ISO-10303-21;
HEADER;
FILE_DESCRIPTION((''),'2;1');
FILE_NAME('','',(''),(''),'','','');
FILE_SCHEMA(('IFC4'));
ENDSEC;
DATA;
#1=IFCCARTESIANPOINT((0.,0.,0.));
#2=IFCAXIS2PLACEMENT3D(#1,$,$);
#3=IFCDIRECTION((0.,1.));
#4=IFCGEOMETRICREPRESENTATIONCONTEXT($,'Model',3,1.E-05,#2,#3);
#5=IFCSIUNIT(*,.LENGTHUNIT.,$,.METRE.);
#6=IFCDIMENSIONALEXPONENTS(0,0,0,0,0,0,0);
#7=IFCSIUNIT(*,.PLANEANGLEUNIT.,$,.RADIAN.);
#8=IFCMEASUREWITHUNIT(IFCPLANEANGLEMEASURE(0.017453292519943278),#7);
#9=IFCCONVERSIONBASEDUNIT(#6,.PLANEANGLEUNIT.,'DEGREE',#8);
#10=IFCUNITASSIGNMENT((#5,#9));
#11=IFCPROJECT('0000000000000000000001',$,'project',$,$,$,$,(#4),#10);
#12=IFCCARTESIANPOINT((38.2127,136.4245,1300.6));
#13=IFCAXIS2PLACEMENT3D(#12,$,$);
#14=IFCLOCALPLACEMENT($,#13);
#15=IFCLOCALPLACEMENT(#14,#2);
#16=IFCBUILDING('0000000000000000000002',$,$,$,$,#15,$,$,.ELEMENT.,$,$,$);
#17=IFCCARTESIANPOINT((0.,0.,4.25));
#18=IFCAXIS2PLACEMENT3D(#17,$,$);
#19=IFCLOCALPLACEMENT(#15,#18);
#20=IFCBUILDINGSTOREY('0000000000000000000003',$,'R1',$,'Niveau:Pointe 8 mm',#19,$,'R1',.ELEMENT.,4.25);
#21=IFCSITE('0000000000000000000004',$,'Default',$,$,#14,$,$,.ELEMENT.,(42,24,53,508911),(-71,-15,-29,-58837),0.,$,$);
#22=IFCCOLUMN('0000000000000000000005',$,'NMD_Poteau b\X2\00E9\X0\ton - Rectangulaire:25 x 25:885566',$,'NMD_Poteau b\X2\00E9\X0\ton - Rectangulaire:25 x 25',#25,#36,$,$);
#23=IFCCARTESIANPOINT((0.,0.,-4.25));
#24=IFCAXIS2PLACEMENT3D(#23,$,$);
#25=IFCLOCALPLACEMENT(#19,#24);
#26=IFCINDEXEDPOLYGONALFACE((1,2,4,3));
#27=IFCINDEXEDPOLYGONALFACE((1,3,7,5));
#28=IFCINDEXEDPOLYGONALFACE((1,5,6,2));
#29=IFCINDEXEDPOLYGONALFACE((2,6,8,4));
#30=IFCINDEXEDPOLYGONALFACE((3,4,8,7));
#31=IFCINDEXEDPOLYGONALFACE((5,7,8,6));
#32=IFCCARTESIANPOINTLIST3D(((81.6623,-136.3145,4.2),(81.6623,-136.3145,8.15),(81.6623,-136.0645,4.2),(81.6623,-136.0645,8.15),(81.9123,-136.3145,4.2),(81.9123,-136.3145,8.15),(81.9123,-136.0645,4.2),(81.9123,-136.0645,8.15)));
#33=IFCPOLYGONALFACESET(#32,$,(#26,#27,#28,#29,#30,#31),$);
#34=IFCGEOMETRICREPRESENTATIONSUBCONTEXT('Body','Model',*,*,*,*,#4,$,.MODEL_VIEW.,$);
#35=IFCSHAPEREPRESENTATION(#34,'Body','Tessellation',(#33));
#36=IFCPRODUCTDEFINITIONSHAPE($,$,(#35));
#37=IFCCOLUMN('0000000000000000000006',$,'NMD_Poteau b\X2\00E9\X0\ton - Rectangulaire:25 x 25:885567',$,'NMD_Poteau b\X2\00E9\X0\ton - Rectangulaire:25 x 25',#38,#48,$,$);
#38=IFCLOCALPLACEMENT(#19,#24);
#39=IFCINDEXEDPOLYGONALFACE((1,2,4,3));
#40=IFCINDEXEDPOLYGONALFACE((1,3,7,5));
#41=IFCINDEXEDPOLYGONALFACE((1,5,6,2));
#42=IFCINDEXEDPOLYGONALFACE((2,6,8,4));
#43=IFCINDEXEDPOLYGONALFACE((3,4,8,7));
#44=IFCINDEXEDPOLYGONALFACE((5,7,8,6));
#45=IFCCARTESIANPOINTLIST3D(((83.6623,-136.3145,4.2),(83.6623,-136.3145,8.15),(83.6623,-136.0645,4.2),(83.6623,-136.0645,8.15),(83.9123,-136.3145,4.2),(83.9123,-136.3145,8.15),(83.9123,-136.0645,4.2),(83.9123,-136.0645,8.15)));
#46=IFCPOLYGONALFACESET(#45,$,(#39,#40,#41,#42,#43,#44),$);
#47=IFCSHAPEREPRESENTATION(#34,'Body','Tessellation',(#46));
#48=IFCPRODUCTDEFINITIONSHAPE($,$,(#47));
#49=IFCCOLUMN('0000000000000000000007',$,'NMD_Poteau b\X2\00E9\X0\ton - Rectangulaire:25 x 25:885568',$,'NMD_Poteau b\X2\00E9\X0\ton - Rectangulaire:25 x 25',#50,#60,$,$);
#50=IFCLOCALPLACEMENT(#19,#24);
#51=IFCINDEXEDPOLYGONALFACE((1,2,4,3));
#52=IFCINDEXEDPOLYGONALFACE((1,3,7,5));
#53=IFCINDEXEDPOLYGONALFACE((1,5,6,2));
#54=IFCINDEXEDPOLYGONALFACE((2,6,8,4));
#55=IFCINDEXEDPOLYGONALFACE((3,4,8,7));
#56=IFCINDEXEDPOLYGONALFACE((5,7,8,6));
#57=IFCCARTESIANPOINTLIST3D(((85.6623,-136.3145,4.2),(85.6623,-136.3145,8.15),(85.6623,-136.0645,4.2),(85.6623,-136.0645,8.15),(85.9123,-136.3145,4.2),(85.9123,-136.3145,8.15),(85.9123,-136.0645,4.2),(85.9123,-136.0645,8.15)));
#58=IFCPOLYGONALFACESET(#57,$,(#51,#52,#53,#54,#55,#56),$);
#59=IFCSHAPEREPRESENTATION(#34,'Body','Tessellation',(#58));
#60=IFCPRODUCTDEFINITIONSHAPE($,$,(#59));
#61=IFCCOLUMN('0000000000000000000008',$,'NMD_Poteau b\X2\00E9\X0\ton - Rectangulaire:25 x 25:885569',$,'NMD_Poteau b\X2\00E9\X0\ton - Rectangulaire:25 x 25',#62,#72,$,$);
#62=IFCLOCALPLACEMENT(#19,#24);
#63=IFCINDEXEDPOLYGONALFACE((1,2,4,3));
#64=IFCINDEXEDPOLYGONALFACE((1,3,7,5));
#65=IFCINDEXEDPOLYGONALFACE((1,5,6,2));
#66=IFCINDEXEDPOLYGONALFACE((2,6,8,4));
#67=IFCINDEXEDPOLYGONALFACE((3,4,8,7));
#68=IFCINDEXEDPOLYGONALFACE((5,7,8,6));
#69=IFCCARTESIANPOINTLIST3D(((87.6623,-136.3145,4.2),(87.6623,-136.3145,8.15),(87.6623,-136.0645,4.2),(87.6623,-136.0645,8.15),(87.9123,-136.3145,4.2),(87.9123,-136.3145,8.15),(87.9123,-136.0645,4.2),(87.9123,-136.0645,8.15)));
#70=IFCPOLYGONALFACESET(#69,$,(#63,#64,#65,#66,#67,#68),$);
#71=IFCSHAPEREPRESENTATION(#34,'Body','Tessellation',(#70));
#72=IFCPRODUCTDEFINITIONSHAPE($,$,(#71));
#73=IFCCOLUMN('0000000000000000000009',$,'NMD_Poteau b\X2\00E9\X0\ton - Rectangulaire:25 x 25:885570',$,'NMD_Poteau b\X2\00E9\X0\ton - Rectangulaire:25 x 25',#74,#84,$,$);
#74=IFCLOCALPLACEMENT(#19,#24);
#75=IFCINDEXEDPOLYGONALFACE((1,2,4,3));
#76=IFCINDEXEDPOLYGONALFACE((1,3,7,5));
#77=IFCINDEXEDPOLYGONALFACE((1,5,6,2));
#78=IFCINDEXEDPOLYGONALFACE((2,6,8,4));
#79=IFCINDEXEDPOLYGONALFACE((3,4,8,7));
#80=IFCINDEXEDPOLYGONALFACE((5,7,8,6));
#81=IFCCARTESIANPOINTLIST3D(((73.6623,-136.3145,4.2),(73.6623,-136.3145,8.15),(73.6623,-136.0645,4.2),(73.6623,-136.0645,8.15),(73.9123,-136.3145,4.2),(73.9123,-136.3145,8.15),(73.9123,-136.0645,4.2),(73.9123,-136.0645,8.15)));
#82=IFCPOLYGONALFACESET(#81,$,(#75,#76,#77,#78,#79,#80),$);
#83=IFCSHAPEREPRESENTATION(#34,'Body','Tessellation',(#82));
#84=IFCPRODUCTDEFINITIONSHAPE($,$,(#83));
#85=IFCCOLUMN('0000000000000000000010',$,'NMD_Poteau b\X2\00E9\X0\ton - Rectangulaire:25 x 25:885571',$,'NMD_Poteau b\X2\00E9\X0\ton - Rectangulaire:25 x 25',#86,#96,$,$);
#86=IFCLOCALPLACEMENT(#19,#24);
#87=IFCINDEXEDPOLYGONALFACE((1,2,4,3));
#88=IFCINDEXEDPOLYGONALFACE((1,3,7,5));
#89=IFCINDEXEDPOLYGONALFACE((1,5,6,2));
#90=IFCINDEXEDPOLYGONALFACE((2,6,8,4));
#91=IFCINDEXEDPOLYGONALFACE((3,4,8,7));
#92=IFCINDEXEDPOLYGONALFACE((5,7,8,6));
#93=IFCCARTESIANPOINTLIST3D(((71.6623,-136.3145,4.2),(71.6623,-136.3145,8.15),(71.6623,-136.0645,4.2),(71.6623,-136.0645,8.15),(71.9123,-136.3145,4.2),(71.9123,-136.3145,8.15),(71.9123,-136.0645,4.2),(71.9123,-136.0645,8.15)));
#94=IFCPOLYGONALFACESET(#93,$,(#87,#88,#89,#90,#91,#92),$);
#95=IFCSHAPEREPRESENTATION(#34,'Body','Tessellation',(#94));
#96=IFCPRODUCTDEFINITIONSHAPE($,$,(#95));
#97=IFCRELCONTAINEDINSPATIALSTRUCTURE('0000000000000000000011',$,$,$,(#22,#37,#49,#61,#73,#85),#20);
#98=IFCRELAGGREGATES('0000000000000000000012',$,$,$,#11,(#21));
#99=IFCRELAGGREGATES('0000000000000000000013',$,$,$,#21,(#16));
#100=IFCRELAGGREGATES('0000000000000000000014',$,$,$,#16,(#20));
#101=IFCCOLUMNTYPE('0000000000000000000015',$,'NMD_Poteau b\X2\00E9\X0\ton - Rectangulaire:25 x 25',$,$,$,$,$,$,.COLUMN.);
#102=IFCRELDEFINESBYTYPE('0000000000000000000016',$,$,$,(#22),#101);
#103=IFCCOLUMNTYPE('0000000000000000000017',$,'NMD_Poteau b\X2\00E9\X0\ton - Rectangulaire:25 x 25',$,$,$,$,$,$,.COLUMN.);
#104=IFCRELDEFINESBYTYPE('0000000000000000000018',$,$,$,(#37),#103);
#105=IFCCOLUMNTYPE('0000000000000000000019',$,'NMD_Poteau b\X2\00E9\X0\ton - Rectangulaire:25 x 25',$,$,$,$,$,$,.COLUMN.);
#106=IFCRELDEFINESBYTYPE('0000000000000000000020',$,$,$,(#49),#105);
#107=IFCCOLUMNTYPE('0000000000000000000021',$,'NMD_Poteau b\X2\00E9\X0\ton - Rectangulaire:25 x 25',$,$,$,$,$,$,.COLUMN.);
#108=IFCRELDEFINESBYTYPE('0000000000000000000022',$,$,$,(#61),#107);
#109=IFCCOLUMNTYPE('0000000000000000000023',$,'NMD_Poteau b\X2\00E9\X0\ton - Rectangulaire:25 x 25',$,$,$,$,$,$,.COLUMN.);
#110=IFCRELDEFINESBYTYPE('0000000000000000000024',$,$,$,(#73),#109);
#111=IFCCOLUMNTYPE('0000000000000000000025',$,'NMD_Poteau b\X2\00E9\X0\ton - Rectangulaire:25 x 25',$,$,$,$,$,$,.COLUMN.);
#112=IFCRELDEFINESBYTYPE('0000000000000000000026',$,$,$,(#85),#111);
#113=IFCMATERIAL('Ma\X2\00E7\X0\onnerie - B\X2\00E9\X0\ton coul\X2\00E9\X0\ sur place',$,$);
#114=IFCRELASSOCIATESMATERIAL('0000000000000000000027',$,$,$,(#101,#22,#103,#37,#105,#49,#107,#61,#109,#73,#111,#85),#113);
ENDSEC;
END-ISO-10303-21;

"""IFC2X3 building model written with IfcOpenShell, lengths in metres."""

from ifc_helpers import new_model, entity, si_unit, converted_unit, direction, frame, frame_2d, origin, place, context, subcontext, project, spatial, rectangle, extrude, source, transform, mapped, material, type_object, type_shapes, element, save


model = new_model("IFC2X3")

# Units and contexts
model_context = context("Model", 3, precision=1e-05, world=origin(), true_north=direction((0.0, 1.0)))
body_context = subcontext(model_context, "Body", "Model", "MODEL_VIEW")
ifc_project = project(units=[si_unit("LENGTHUNIT", "METRE"), converted_unit("PLANEANGLEUNIT", "DEGREE", entity("IfcPlaneAngleMeasure", 0.017453292519943278), si_unit("PLANEANGLEUNIT", "RADIAN"), dimensions=[0, 0, 0, 0, 0, 0, 0])], contexts=[model_context])

# Site, building, storey
site_placement = place(None, frame((38.2127, 136.4245, 1300.6)))
site = spatial("IfcSite", under=ifc_project, at=site_placement, Name="Default", CompositionType="ELEMENT", RefLatitude=(42, 24, 53, 508911), RefLongitude=(-71, -15, -29, -58837), RefElevation=0.0)
building_placement = place(site_placement, origin())
building = spatial("IfcBuilding", under=site, at=building_placement, CompositionType="ELEMENT")
storey_placement = place(building_placement, frame((0.0, 0.0, 4.25)))
storey = spatial("IfcBuildingStorey", under=building, at=storey_placement, Name="R1", ObjectType="Niveau:Pointe 8 mm", LongName="R1", CompositionType="ELEMENT", Elevation=4.25)

# Columns
ifc_material_1 = material(Name="Maçonnerie - Béton coulé sur place")
column_type_1 = type_object("IfcColumnType", Name="NMD_Poteau béton - Rectangulaire:25 x 25", PredefinedType="COLUMN", material=ifc_material_1)
shared_shape_1 = source(origin(), body_context, "Body", "SweptSolid", [
    extrude(rectangle(XDim=0.25, YDim=0.25, at=frame_2d((0.0, 0.0), x_axis=(1.0, 0.0))), frame((81.7873, -136.1895, 4.2), z_axis=(0.0, 0.0, 1.0), x_axis=(-1.0, 0.0, 0.0)), (0.0, 0.0, 1.0), 3.95),
])
type_shapes(column_type_1, [shared_shape_1])
column_1_placement = place(storey_placement, frame((0.0, 0.0, -4.25)))
element("IfcColumn", 1, at=column_1_placement, inside=storey, type_object=column_type_1, material=ifc_material_1, Name="NMD_Poteau béton - Rectangulaire:25 x 25:885566", ObjectType="NMD_Poteau béton - Rectangulaire:25 x 25", context=body_context, shape_type="MappedRepresentation", body=[
    mapped(shared_shape_1, transform((0.0, 0.0, 0.0), scale=1.0)),
])
column_type_2 = type_object("IfcColumnType", Name="NMD_Poteau béton - Rectangulaire:25 x 25", PredefinedType="COLUMN", material=ifc_material_1)
shared_shape_2 = source(origin(), body_context, "Body", "SweptSolid", [
    extrude(rectangle(XDim=0.25, YDim=0.25, at=frame_2d((0.0, 0.0), x_axis=(1.0, 0.0))), frame((83.7873, -136.1895, 4.2), z_axis=(0.0, 0.0, 1.0), x_axis=(-1.0, 0.0, 0.0)), (0.0, 0.0, 1.0), 3.95),
])
type_shapes(column_type_2, [shared_shape_2])
column_2_placement = place(storey_placement, frame((0.0, 0.0, -4.25)))
element("IfcColumn", 2, at=column_2_placement, inside=storey, type_object=column_type_2, material=ifc_material_1, Name="NMD_Poteau béton - Rectangulaire:25 x 25:885567", ObjectType="NMD_Poteau béton - Rectangulaire:25 x 25", context=body_context, shape_type="MappedRepresentation", body=[
    mapped(shared_shape_2, transform((0.0, 0.0, 0.0), scale=1.0)),
])
column_type_3 = type_object("IfcColumnType", Name="NMD_Poteau béton - Rectangulaire:25 x 25", PredefinedType="COLUMN", material=ifc_material_1)
shared_shape_3 = source(origin(), body_context, "Body", "SweptSolid", [
    extrude(rectangle(XDim=0.25, YDim=0.25, at=frame_2d((0.0, 0.0), x_axis=(1.0, 0.0))), frame((85.7873, -136.1895, 4.2), z_axis=(0.0, 0.0, 1.0), x_axis=(-1.0, 0.0, 0.0)), (0.0, 0.0, 1.0), 3.95),
])
type_shapes(column_type_3, [shared_shape_3])
column_3_placement = place(storey_placement, frame((0.0, 0.0, -4.25)))
element("IfcColumn", 3, at=column_3_placement, inside=storey, type_object=column_type_3, material=ifc_material_1, Name="NMD_Poteau béton - Rectangulaire:25 x 25:885568", ObjectType="NMD_Poteau béton - Rectangulaire:25 x 25", context=body_context, shape_type="MappedRepresentation", body=[
    mapped(shared_shape_3, transform((0.0, 0.0, 0.0), scale=1.0)),
])
column_type_4 = type_object("IfcColumnType", Name="NMD_Poteau béton - Rectangulaire:25 x 25", PredefinedType="COLUMN", material=ifc_material_1)
shared_shape_4 = source(origin(), body_context, "Body", "SweptSolid", [
    extrude(rectangle(XDim=0.25, YDim=0.25, at=frame_2d((0.0, 0.0), x_axis=(1.0, 0.0))), frame((87.7873, -136.1895, 4.2), z_axis=(0.0, 0.0, 1.0), x_axis=(-1.0, 0.0, 0.0)), (0.0, 0.0, 1.0), 3.95),
])
type_shapes(column_type_4, [shared_shape_4])
column_4_placement = place(storey_placement, frame((0.0, 0.0, -4.25)))
element("IfcColumn", 4, at=column_4_placement, inside=storey, type_object=column_type_4, material=ifc_material_1, Name="NMD_Poteau béton - Rectangulaire:25 x 25:885569", ObjectType="NMD_Poteau béton - Rectangulaire:25 x 25", context=body_context, shape_type="MappedRepresentation", body=[
    mapped(shared_shape_4, transform((0.0, 0.0, 0.0), scale=1.0)),
])
column_type_5 = type_object("IfcColumnType", Name="NMD_Poteau béton - Rectangulaire:25 x 25", PredefinedType="COLUMN", material=ifc_material_1)
shared_shape_5 = source(origin(), body_context, "Body", "SweptSolid", [
    extrude(rectangle(XDim=0.25, YDim=0.25, at=frame_2d((0.0, 0.0), x_axis=(1.0, 0.0))), frame((73.7873, -136.1895, 4.2), z_axis=(0.0, 0.0, 1.0), x_axis=(-1.0, 0.0, 0.0)), (0.0, 0.0, 1.0), 3.95),
])
type_shapes(column_type_5, [shared_shape_5])
column_5_placement = place(storey_placement, frame((0.0, 0.0, -4.25)))
element("IfcColumn", 5, at=column_5_placement, inside=storey, type_object=column_type_5, material=ifc_material_1, Name="NMD_Poteau béton - Rectangulaire:25 x 25:885570", ObjectType="NMD_Poteau béton - Rectangulaire:25 x 25", context=body_context, shape_type="MappedRepresentation", body=[
    mapped(shared_shape_5, transform((0.0, 0.0, 0.0), scale=1.0)),
])
column_type_6 = type_object("IfcColumnType", Name="NMD_Poteau béton - Rectangulaire:25 x 25", PredefinedType="COLUMN", material=ifc_material_1)
shared_shape_6 = source(origin(), body_context, "Body", "SweptSolid", [
    extrude(rectangle(XDim=0.25, YDim=0.25, at=frame_2d((0.0, 0.0), x_axis=(1.0, 0.0))), frame((71.7873, -136.1895, 4.2), z_axis=(0.0, 0.0, 1.0), x_axis=(-1.0, 0.0, 0.0)), (0.0, 0.0, 1.0), 3.95),
])
type_shapes(column_type_6, [shared_shape_6])
column_6_placement = place(storey_placement, frame((0.0, 0.0, -4.25)))
element("IfcColumn", 6, at=column_6_placement, inside=storey, type_object=column_type_6, material=ifc_material_1, Name="NMD_Poteau béton - Rectangulaire:25 x 25:885571", ObjectType="NMD_Poteau béton - Rectangulaire:25 x 25", context=body_context, shape_type="MappedRepresentation", body=[
    mapped(shared_shape_6, transform((0.0, 0.0, 0.0), scale=1.0)),
])

save(model, "model.ifc")
